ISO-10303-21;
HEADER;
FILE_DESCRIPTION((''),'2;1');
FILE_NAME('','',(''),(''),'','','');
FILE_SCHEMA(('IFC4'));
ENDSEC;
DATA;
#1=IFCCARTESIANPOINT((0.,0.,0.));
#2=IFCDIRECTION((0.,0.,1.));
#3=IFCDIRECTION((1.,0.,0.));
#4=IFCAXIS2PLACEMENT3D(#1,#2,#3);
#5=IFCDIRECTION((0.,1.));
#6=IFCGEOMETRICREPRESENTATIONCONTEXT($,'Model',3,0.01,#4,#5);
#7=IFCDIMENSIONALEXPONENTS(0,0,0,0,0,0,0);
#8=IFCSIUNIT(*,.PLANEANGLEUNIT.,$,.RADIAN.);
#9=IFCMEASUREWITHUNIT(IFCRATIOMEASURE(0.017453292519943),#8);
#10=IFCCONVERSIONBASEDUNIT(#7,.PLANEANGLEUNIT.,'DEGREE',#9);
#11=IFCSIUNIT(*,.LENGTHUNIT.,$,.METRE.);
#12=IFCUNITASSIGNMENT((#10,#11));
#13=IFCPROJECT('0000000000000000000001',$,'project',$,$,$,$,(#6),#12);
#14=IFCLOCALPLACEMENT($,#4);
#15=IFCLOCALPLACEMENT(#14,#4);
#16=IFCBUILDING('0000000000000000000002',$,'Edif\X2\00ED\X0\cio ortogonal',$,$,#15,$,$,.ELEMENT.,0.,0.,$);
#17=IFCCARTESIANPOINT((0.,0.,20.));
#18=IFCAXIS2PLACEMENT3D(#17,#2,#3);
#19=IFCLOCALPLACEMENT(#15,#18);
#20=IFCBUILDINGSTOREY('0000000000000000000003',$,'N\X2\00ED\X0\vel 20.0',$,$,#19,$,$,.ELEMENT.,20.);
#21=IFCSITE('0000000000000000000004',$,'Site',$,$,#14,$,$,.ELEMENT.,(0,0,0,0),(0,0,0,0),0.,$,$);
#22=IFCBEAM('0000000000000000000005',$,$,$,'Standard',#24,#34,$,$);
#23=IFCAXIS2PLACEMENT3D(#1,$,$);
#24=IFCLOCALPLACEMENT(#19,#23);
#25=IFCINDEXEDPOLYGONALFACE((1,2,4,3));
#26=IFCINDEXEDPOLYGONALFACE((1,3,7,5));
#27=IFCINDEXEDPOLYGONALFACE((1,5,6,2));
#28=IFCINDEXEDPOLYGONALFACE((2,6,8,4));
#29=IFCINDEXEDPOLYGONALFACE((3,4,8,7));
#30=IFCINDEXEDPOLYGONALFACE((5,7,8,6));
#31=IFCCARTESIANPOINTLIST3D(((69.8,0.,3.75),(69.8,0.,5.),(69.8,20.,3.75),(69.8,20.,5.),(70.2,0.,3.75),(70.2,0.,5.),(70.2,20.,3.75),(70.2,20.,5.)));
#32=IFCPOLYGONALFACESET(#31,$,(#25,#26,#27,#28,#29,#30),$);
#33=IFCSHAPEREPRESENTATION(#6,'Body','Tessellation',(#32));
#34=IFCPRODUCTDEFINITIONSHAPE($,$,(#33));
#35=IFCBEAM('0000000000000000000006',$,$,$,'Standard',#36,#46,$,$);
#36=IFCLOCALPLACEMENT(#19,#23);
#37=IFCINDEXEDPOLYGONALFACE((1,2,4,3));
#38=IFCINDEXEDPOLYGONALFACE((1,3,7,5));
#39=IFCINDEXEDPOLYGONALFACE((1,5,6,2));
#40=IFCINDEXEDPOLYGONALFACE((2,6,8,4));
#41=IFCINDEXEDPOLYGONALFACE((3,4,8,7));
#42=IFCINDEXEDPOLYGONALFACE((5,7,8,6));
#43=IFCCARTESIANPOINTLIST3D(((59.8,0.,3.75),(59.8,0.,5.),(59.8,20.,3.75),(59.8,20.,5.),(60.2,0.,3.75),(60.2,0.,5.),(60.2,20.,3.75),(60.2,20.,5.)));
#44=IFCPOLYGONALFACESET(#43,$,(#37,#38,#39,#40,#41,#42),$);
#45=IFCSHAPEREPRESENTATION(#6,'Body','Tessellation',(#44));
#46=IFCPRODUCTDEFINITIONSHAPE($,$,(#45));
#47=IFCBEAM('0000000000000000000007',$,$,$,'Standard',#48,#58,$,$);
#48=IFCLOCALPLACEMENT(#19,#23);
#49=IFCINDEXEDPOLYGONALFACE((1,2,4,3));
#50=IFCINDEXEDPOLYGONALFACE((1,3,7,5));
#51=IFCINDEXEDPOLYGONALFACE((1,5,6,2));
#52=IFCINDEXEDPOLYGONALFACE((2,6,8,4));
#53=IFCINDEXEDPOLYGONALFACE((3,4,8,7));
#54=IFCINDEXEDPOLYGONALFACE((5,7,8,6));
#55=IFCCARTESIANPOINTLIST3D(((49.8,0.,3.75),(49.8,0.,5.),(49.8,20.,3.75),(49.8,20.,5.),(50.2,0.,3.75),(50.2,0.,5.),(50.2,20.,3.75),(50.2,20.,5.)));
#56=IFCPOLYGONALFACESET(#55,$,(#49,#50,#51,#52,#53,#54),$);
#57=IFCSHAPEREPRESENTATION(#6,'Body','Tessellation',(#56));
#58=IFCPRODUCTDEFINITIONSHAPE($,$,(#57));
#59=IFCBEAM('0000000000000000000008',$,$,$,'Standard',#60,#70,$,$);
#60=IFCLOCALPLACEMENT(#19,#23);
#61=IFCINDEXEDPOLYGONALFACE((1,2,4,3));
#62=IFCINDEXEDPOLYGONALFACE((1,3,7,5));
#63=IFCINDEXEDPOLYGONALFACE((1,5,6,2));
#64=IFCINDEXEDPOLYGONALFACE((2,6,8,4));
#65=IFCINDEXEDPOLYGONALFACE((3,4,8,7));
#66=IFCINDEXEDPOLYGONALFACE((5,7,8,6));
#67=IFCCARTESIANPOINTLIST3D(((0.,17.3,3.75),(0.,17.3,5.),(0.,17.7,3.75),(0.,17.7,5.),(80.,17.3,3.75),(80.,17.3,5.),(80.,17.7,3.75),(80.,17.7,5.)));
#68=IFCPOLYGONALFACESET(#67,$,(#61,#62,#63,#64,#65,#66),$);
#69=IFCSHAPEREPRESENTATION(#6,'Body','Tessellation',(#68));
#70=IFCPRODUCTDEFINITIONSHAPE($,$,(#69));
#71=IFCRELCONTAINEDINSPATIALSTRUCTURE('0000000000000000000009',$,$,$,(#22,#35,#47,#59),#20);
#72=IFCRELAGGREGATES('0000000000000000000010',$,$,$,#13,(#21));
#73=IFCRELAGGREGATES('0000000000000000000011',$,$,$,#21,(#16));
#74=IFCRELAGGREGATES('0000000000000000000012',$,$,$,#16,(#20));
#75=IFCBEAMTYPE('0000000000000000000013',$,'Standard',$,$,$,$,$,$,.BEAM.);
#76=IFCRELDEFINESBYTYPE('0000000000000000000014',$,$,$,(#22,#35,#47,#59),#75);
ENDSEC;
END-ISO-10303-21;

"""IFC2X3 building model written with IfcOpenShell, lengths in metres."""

from ifc_helpers import new_model, entity, si_unit, converted_unit, direction, frame, origin_with_axes, origin_2d, place, context, project, spatial, rectangle, extrude, type_object, element, save


model = new_model("IFC2X3")

# Units and contexts
model_context = context("Model", 3, precision=0.01, world=origin_with_axes(), true_north=direction((0.0, 1.0)))
ifc_project = project(units=[converted_unit("PLANEANGLEUNIT", "DEGREE", entity("IfcRatioMeasure", 0.017453292519943), si_unit("PLANEANGLEUNIT", "RADIAN"), dimensions=[0, 0, 0, 0, 0, 0, 0]), si_unit("LENGTHUNIT", "METRE")], contexts=[model_context])

# Site, building, storey
site_placement = place(None, origin_with_axes())
site = spatial("IfcSite", under=ifc_project, at=site_placement, Name="Site", CompositionType="ELEMENT", RefLatitude=(0, 0, 0, 0), RefLongitude=(0, 0, 0, 0), RefElevation=0.0)
building_placement = place(site_placement, origin_with_axes())
building = spatial("IfcBuilding", under=site, at=building_placement, Name="Edifício ortogonal", CompositionType="ELEMENT", ElevationOfRefHeight=0.0, ElevationOfTerrain=0.0)
storey_placement = place(building_placement, frame((0.0, 0.0, 20.0), z_axis=(0.0, 0.0, 1.0), x_axis=(1.0, 0.0, 0.0)))
storey = spatial("IfcBuildingStorey", under=building, at=storey_placement, Name="Nível 20.0", CompositionType="ELEMENT", Elevation=20.0)

# Beams
beam_type = type_object("IfcBeamType", Name="Standard", PredefinedType="BEAM")
for number, where, z_axis, x_axis in (
    (1, (70.0, 20.0, 25.0), (0.0, 0.0, 1.0), (0.0, -1.0, 0.0)),
    (2, (60.0, 20.0, 25.0), (0.0, 0.0, 1.0), (0.0, -1.0, 0.0)),
    (3, (50.0, 20.0, 25.0), (0.0, 0.0, 1.0), (0.0, -1.0, 0.0)),
):
    element("IfcBeam", number, at=place(site_placement, frame(where, z_axis=z_axis, x_axis=x_axis)), inside=storey, type_object=beam_type, ObjectType="Standard", context=model_context, shape_type="SweptSolid", body=[
        extrude(rectangle(XDim=0.4, YDim=1.25, at=origin_2d()), frame((0.0, 0.0, -0.625), z_axis=(1.0, 0.0, 0.0), x_axis=(0.0, 1.0, 0.0)), (0.0, 0.0, 1.0), 20.0),
    ])
beam_placement = place(site_placement, frame((80.0, 17.5, 25.0), z_axis=(0.0, 0.0, 1.0), x_axis=(-1.0, 0.0, 0.0)))
element("IfcBeam", 4, at=beam_placement, inside=storey, type_object=beam_type, ObjectType="Standard", context=model_context, shape_type="SweptSolid", body=[
    extrude(rectangle(XDim=0.4, YDim=1.25, at=origin_2d()), frame((0.0, 0.0, -0.625), z_axis=(1.0, 0.0, 0.0), x_axis=(0.0, 1.0, 0.0)), (0.0, 0.0, 1.0), 80.0),
])

save(model, "model.ifc")
